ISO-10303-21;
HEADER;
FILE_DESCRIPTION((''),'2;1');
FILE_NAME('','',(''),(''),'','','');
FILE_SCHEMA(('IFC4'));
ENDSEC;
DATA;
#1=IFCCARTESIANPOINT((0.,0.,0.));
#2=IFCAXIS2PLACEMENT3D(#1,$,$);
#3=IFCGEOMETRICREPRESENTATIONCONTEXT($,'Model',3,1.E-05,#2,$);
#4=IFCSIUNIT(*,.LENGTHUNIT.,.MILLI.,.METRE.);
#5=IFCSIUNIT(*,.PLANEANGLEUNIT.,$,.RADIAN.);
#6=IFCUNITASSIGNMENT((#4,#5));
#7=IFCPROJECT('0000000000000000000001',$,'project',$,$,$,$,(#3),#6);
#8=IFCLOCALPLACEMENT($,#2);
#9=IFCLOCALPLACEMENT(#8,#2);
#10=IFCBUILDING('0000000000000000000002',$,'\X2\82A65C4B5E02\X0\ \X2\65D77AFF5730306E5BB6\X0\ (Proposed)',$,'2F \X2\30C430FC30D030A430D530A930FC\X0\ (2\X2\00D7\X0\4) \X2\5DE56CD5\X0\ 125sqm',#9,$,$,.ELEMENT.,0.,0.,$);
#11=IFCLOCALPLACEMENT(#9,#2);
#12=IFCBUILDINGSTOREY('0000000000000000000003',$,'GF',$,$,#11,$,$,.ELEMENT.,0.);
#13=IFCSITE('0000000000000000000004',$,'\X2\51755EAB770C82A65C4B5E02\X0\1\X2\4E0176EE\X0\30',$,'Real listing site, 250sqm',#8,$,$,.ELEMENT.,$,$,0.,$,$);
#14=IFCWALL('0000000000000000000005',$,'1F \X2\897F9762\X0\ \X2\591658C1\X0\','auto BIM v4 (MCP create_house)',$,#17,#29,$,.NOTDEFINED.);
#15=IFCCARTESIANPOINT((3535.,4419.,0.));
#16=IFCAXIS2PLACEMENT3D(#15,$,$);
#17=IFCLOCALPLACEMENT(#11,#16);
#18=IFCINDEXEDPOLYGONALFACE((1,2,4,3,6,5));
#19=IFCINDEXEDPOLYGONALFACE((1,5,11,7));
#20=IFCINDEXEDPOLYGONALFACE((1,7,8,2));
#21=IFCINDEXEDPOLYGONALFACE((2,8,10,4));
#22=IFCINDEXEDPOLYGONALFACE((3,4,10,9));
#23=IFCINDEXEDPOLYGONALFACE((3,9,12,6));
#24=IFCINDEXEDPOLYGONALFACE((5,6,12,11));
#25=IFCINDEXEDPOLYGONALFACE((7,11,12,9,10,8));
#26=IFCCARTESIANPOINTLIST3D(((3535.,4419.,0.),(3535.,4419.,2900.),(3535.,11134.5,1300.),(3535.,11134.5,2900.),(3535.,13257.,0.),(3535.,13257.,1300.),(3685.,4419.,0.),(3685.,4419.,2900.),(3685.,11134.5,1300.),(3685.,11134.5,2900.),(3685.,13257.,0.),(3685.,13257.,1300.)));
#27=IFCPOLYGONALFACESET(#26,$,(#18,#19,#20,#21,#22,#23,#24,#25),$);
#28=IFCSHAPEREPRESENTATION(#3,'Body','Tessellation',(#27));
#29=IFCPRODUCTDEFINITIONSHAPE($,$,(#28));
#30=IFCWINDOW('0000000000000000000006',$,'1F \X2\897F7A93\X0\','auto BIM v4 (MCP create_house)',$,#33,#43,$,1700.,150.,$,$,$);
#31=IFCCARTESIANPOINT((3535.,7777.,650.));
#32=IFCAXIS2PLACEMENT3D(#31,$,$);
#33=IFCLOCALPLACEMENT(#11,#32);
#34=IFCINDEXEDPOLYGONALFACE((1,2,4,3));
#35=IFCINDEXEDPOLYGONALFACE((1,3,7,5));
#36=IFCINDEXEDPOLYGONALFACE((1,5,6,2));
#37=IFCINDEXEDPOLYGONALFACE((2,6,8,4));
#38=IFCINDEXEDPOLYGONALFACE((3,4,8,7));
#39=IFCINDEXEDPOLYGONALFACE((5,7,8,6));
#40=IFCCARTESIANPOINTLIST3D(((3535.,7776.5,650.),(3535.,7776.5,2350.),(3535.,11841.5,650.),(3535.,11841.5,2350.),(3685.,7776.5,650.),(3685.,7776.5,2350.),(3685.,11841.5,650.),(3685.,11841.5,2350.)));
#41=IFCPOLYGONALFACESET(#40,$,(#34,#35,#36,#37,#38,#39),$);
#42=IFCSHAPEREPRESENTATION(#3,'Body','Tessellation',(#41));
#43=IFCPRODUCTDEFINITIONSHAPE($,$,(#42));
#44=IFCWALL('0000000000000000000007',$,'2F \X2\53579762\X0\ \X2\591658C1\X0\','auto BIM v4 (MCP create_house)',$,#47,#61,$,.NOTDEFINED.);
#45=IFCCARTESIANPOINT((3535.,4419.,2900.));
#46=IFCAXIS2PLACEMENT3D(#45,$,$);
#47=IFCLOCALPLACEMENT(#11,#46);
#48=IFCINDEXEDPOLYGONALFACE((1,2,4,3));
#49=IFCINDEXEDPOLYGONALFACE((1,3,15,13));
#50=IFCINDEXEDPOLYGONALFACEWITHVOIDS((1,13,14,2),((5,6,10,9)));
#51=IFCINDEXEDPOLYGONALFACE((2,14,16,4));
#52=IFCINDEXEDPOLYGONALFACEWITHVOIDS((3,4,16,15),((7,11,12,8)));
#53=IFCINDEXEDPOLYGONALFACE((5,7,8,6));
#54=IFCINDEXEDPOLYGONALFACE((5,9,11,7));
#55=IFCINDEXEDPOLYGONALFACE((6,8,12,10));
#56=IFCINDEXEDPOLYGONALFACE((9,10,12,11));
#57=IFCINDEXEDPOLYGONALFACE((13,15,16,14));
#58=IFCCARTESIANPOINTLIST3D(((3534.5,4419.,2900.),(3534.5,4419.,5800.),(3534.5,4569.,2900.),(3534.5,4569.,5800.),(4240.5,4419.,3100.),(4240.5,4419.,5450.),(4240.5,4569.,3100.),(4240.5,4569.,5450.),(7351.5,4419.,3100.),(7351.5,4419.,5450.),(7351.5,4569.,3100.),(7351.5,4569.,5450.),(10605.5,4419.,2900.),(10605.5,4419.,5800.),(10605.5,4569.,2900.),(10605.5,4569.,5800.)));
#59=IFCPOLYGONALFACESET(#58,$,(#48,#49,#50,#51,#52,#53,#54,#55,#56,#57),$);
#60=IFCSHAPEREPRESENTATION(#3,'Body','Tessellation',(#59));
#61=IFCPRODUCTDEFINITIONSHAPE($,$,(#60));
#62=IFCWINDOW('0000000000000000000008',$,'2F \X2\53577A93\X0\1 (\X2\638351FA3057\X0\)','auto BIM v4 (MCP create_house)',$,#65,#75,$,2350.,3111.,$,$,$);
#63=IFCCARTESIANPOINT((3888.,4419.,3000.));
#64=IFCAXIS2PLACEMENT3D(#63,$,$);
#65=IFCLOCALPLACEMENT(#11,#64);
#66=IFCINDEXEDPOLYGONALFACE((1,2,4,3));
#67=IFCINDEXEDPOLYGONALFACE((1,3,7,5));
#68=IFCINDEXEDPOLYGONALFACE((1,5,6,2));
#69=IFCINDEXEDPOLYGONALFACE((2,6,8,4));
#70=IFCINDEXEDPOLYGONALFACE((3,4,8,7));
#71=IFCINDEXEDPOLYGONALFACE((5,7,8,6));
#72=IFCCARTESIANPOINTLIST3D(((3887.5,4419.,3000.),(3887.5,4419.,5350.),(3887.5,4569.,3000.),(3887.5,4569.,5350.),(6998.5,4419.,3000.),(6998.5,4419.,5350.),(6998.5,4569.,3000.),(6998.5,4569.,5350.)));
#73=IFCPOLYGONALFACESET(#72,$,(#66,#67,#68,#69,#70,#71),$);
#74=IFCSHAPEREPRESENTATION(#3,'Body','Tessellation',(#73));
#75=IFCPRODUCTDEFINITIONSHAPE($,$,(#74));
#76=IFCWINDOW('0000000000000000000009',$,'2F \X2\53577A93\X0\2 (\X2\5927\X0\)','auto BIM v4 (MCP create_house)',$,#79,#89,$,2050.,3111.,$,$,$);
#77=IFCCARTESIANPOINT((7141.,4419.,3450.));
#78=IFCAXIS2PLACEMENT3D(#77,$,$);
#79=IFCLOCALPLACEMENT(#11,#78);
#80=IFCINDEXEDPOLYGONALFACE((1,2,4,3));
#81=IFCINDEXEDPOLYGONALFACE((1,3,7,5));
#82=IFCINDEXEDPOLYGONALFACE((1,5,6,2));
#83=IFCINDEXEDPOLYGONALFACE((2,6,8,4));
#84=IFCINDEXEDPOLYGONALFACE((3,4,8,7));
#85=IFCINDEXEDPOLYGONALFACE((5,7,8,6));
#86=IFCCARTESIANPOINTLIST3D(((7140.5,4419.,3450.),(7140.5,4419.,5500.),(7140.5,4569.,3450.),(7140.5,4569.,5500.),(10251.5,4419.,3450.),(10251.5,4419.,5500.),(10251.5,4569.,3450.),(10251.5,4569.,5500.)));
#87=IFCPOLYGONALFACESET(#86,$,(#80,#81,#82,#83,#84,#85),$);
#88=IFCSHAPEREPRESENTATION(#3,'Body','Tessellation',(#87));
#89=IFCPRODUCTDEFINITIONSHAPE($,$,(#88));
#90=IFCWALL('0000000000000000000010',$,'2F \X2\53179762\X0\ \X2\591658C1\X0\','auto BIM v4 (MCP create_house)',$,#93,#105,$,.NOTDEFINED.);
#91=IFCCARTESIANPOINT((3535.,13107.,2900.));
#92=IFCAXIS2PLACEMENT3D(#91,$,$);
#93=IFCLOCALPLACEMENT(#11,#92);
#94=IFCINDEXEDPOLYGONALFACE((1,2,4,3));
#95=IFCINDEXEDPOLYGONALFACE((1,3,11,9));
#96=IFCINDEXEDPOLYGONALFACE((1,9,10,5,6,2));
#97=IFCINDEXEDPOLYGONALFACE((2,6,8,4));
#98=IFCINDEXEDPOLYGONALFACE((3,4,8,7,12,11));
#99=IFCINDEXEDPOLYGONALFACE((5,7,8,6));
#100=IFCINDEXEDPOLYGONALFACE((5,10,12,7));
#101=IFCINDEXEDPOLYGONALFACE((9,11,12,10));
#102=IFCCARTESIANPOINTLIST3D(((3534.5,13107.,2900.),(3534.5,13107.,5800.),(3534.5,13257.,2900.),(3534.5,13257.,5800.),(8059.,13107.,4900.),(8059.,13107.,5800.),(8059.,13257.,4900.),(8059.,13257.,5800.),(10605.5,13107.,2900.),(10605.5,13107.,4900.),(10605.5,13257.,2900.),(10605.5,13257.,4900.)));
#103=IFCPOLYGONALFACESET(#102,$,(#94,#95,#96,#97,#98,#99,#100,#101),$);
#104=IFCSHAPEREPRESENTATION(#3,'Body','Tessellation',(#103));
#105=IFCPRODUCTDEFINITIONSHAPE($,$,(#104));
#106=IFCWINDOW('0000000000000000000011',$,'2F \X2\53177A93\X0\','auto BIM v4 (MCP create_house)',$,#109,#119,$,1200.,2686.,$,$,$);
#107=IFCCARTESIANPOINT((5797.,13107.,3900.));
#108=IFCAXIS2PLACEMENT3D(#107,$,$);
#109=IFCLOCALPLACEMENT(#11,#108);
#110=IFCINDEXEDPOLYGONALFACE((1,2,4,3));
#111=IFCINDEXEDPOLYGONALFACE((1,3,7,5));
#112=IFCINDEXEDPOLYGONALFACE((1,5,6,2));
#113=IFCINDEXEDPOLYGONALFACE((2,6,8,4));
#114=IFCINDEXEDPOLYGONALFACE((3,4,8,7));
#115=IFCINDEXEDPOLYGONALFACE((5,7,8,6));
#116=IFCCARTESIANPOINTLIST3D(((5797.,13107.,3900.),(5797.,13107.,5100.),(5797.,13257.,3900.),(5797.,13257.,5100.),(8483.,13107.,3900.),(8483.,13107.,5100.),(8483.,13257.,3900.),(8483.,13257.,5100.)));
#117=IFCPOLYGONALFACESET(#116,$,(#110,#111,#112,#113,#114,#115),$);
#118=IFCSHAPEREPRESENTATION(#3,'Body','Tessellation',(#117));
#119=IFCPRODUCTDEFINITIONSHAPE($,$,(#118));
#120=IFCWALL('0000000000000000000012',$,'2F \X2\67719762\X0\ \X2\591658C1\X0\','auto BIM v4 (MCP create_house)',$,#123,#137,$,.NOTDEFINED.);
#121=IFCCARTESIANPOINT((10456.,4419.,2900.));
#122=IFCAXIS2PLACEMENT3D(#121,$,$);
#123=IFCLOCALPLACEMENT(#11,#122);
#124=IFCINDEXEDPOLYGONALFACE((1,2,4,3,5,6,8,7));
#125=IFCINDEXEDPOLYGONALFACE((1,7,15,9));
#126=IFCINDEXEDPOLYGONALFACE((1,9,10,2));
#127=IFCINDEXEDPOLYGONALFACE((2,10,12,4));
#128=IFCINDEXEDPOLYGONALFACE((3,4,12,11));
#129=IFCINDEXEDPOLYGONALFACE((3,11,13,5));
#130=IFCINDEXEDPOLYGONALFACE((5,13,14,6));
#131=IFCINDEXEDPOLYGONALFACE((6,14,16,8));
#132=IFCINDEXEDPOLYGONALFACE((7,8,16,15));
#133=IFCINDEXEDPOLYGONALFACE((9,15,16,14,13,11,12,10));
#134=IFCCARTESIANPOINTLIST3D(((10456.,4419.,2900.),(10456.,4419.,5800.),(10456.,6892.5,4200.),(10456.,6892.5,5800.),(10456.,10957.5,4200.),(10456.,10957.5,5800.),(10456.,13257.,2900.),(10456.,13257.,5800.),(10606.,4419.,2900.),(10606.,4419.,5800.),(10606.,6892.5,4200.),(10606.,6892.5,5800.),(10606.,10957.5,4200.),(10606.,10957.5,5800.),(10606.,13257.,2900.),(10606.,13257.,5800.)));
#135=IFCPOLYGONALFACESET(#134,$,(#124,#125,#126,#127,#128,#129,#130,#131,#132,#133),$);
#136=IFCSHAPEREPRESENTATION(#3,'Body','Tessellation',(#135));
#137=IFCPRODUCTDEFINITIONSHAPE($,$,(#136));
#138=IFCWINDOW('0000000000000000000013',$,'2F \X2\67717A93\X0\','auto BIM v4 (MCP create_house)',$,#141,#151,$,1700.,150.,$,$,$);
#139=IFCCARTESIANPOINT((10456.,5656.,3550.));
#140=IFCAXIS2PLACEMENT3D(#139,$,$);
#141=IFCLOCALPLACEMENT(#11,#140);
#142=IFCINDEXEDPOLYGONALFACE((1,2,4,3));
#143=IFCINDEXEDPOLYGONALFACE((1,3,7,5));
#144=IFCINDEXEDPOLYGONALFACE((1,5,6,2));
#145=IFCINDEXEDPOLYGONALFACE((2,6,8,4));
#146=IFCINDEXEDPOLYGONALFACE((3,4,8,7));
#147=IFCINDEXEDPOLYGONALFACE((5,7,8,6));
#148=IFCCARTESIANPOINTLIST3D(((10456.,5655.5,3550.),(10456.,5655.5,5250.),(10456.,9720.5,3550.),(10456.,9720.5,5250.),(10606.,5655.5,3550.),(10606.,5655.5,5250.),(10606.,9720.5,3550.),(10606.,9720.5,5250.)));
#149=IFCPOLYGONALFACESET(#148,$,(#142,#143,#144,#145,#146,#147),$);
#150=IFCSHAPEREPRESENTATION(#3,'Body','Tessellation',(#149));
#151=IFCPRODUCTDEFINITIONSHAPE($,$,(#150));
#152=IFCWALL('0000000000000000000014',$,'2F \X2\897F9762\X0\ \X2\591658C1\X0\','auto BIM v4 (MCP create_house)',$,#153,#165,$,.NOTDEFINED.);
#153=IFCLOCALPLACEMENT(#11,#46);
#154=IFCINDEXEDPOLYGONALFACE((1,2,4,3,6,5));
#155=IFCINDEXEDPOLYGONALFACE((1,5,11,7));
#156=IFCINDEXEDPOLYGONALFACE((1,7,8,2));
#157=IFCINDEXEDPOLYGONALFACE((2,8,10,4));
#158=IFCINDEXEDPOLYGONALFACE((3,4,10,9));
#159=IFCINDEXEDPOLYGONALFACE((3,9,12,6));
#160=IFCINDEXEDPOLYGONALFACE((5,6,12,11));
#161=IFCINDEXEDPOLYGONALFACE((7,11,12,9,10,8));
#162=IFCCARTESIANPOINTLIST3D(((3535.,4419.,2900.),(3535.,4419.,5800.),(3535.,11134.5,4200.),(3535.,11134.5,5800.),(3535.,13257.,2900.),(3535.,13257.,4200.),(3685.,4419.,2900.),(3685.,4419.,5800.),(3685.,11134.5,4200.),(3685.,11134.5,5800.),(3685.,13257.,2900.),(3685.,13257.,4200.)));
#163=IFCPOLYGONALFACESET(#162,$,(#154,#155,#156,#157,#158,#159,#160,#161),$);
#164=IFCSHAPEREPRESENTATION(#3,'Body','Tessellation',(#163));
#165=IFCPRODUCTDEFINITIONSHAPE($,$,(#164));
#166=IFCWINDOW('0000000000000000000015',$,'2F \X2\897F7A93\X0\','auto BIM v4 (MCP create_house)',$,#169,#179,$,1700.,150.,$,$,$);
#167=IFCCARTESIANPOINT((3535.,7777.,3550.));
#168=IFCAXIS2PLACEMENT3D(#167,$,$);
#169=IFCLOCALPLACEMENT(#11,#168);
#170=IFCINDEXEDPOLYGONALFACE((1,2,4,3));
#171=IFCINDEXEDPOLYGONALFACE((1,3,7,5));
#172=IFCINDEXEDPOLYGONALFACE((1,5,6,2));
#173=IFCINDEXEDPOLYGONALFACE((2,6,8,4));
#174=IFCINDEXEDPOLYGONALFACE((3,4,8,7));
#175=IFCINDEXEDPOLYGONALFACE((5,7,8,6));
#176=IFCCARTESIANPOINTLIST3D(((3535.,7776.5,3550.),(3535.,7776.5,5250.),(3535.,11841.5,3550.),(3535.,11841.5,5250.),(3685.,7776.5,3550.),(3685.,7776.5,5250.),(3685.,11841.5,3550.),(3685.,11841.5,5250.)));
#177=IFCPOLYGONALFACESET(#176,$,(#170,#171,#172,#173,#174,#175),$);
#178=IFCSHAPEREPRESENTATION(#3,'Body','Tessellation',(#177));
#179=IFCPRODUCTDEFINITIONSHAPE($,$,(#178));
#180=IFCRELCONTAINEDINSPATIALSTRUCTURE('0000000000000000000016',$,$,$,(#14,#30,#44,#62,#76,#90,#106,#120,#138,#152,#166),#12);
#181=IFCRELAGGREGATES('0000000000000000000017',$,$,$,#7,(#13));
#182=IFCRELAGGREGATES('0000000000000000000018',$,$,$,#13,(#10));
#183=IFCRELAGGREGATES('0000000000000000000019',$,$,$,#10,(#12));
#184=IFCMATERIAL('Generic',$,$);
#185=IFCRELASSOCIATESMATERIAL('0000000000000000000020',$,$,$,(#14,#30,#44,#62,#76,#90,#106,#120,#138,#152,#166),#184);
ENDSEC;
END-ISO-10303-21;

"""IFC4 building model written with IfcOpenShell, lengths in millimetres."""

from ifc_helpers import new_model, si_unit, frame, frame_2d, origin, place, context, project, spatial, rectangle, extrude, material, element, fill, save


model = new_model("IFC4")

# Units and contexts
model_context = context("Model", 3, precision=1e-05, world=origin())
ifc_project = project(units=[si_unit("LENGTHUNIT", "METRE", prefix="MILLI"), si_unit("PLANEANGLEUNIT", "RADIAN")], contexts=[model_context])

# Site, building, storey
site_placement = place(None, origin())
site = spatial("IfcSite", under=ifc_project, at=site_placement, Name="兵庫県芦屋市1丁目30", ObjectType="Real listing site, 250sqm", CompositionType="ELEMENT", RefElevation=0.0)
building_placement = place(site_placement, origin())
building = spatial("IfcBuilding", under=site, at=building_placement, Name="芦屋市 旗竿地の家 (Proposed)", ObjectType="2F ツーバイフォー (2×4) 工法 125sqm", CompositionType="ELEMENT", ElevationOfRefHeight=0.0, ElevationOfTerrain=0.0)
storey_placement = place(building_placement, origin())
storey = spatial("IfcBuildingStorey", under=building, at=storey_placement, Name="GF", CompositionType="ELEMENT", Elevation=0.0)

# Shared definitions
ifc_material = material(Name="Generic")

# Wall, opening, window
wall_1_placement = place(storey_placement, frame((3535.0, 4419.0, 0.0)))
wall_1 = element("IfcWall", 1, at=wall_1_placement, inside=storey, material=ifc_material, Name="1F 西面 外壁", Description="auto BIM v4 (MCP create_house)", PredefinedType="NOTDEFINED", context=model_context, shape_type="SweptSolid", body=[
    extrude(rectangle(XDim=150.0, YDim=8838.0, at=frame_2d((75.0, 4419.0))), frame((3535.0, 4419.0, 0.0)), (0.0, 0.0, 1.0), 2900.0),
])
opening_1_placement = place(storey_placement, frame((3535.0, 7777.0, 650.0)))
opening_1 = element("IfcOpeningElement", 2, at=opening_1_placement, cuts=wall_1, PredefinedType="NOTDEFINED", context=model_context, shape_type="SweptSolid", body=[
    extrude(rectangle(XDim=150.0, YDim=4065.0, at=frame_2d((75.0, 2032.0))), frame((3535.0, 7777.0, 650.0)), (0.0, 0.0, 1.0), 1700.0),
])
window_1_placement = place(storey_placement, frame((3535.0, 7777.0, 650.0)))
window_1 = element("IfcWindow", 3, at=window_1_placement, inside=storey, material=ifc_material, Name="1F 西窓", Description="auto BIM v4 (MCP create_house)", OverallHeight=1700.0, OverallWidth=150.0, context=model_context, shape_type="SweptSolid", body=[
    extrude(rectangle(XDim=150.0, YDim=4065.0, at=frame_2d((75.0, 2032.0))), frame((3535.0, 7777.0, 650.0)), (0.0, 0.0, 1.0), 1700.0),
])
fill(opening_1, window_1)

# Wall, openings, windows
wall_2_placement = place(storey_placement, frame((3535.0, 4419.0, 2900.0)))
wall_2 = element("IfcWall", 4, at=wall_2_placement, inside=storey, material=ifc_material, Name="2F 南面 外壁", Description="auto BIM v4 (MCP create_house)", PredefinedType="NOTDEFINED", context=model_context, shape_type="SweptSolid", body=[
    extrude(rectangle(XDim=7071.0, YDim=150.0, at=frame_2d((3535.0, 75.0))), frame((3535.0, 4419.0, 2900.0)), (0.0, 0.0, 1.0), 2900.0),
])
opening_2_placement = place(storey_placement, frame((3888.0, 4419.0, 3000.0)))
opening_2 = element("IfcOpeningElement", 5, at=opening_2_placement, cuts=wall_2, PredefinedType="NOTDEFINED", context=model_context, shape_type="SweptSolid", body=[
    extrude(rectangle(XDim=3111.0, YDim=150.0, at=frame_2d((1555.0, 75.0))), frame((3888.0, 4419.0, 3000.0)), (0.0, 0.0, 1.0), 2350.0),
])
opening_3_placement = place(storey_placement, frame((7141.0, 4419.0, 3450.0)))
opening_3 = element("IfcOpeningElement", 6, at=opening_3_placement, cuts=wall_2, PredefinedType="NOTDEFINED", context=model_context, shape_type="SweptSolid", body=[
    extrude(rectangle(XDim=3111.0, YDim=150.0, at=frame_2d((1555.0, 75.0))), frame((7141.0, 4419.0, 3450.0)), (0.0, 0.0, 1.0), 2050.0),
])
window_2_placement = place(storey_placement, frame((3888.0, 4419.0, 3000.0)))
window_2 = element("IfcWindow", 7, at=window_2_placement, inside=storey, material=ifc_material, Name="2F 南窓1 (掃出し)", Description="auto BIM v4 (MCP create_house)", OverallHeight=2350.0, OverallWidth=3111.0, context=model_context, shape_type="SweptSolid", body=[
    extrude(rectangle(XDim=3111.0, YDim=150.0, at=frame_2d((1555.0, 75.0))), frame((3888.0, 4419.0, 3000.0)), (0.0, 0.0, 1.0), 2350.0),
])
fill(opening_2, window_2)
window_3_placement = place(storey_placement, frame((7141.0, 4419.0, 3450.0)))
window_3 = element("IfcWindow", 8, at=window_3_placement, inside=storey, material=ifc_material, Name="2F 南窓2 (大)", Description="auto BIM v4 (MCP create_house)", OverallHeight=2050.0, OverallWidth=3111.0, context=model_context, shape_type="SweptSolid", body=[
    extrude(rectangle(XDim=3111.0, YDim=150.0, at=frame_2d((1555.0, 75.0))), frame((7141.0, 4419.0, 3450.0)), (0.0, 0.0, 1.0), 2050.0),
])
fill(opening_3, window_3)

# Walls, openings, windows
wall_3_placement = place(storey_placement, frame((3535.0, 13107.0, 2900.0)))
wall_3 = element("IfcWall", 9, at=wall_3_placement, inside=storey, material=ifc_material, Name="2F 北面 外壁", Description="auto BIM v4 (MCP create_house)", PredefinedType="NOTDEFINED", context=model_context, shape_type="SweptSolid", body=[
    extrude(rectangle(XDim=7071.0, YDim=150.0, at=frame_2d((3535.0, 75.0))), frame((3535.0, 13107.0, 2900.0)), (0.0, 0.0, 1.0), 2900.0),
])
opening_4_placement = place(storey_placement, frame((5797.0, 13107.0, 3900.0)))
opening_4 = element("IfcOpeningElement", 10, at=opening_4_placement, cuts=wall_3, PredefinedType="NOTDEFINED", context=model_context, shape_type="SweptSolid", body=[
    extrude(rectangle(XDim=2686.0, YDim=150.0, at=frame_2d((1343.0, 75.0))), frame((5797.0, 13107.0, 3900.0)), (0.0, 0.0, 1.0), 1200.0),
])
window_4_placement = place(storey_placement, frame((5797.0, 13107.0, 3900.0)))
window_4 = element("IfcWindow", 11, at=window_4_placement, inside=storey, material=ifc_material, Name="2F 北窓", Description="auto BIM v4 (MCP create_house)", OverallHeight=1200.0, OverallWidth=2686.0, context=model_context, shape_type="SweptSolid", body=[
    extrude(rectangle(XDim=2686.0, YDim=150.0, at=frame_2d((1343.0, 75.0))), frame((5797.0, 13107.0, 3900.0)), (0.0, 0.0, 1.0), 1200.0),
])
fill(opening_4, window_4)
wall_4_placement = place(storey_placement, frame((10456.0, 4419.0, 2900.0)))
wall_4 = element("IfcWall", 12, at=wall_4_placement, inside=storey, material=ifc_material, Name="2F 東面 外壁", Description="auto BIM v4 (MCP create_house)", PredefinedType="NOTDEFINED", context=model_context, shape_type="SweptSolid", body=[
    extrude(rectangle(XDim=150.0, YDim=8838.0, at=frame_2d((75.0, 4419.0))), frame((10456.0, 4419.0, 2900.0)), (0.0, 0.0, 1.0), 2900.0),
])
opening_5_placement = place(storey_placement, frame((10456.0, 5656.0, 3550.0)))
opening_5 = element("IfcOpeningElement", 13, at=opening_5_placement, cuts=wall_4, PredefinedType="NOTDEFINED", context=model_context, shape_type="SweptSolid", body=[
    extrude(rectangle(XDim=150.0, YDim=4065.0, at=frame_2d((75.0, 2032.0))), frame((10456.0, 5656.0, 3550.0)), (0.0, 0.0, 1.0), 1700.0),
])
window_5_placement = place(storey_placement, frame((10456.0, 5656.0, 3550.0)))
window_5 = element("IfcWindow", 14, at=window_5_placement, inside=storey, material=ifc_material, Name="2F 東窓", Description="auto BIM v4 (MCP create_house)", OverallHeight=1700.0, OverallWidth=150.0, context=model_context, shape_type="SweptSolid", body=[
    extrude(rectangle(XDim=150.0, YDim=4065.0, at=frame_2d((75.0, 2032.0))), frame((10456.0, 5656.0, 3550.0)), (0.0, 0.0, 1.0), 1700.0),
])
fill(opening_5, window_5)
wall_5_placement = place(storey_placement, frame((3535.0, 4419.0, 2900.0)))
wall_5 = element("IfcWall", 15, at=wall_5_placement, inside=storey, material=ifc_material, Name="2F 西面 外壁", Description="auto BIM v4 (MCP create_house)", PredefinedType="NOTDEFINED", context=model_context, shape_type="SweptSolid", body=[
    extrude(rectangle(XDim=150.0, YDim=8838.0, at=frame_2d((75.0, 4419.0))), frame((3535.0, 4419.0, 2900.0)), (0.0, 0.0, 1.0), 2900.0),
])
opening_6_placement = place(storey_placement, frame((3535.0, 7777.0, 3550.0)))
opening_6 = element("IfcOpeningElement", 16, at=opening_6_placement, cuts=wall_5, PredefinedType="NOTDEFINED", context=model_context, shape_type="SweptSolid", body=[
    extrude(rectangle(XDim=150.0, YDim=4065.0, at=frame_2d((75.0, 2032.0))), frame((3535.0, 7777.0, 3550.0)), (0.0, 0.0, 1.0), 1700.0),
])
window_6_placement = place(storey_placement, frame((3535.0, 7777.0, 3550.0)))
window_6 = element("IfcWindow", 17, at=window_6_placement, inside=storey, material=ifc_material, Name="2F 西窓", Description="auto BIM v4 (MCP create_house)", OverallHeight=1700.0, OverallWidth=150.0, context=model_context, shape_type="SweptSolid", body=[
    extrude(rectangle(XDim=150.0, YDim=4065.0, at=frame_2d((75.0, 2032.0))), frame((3535.0, 7777.0, 3550.0)), (0.0, 0.0, 1.0), 1700.0),
])
fill(opening_6, window_6)

save(model, "model.ifc")
